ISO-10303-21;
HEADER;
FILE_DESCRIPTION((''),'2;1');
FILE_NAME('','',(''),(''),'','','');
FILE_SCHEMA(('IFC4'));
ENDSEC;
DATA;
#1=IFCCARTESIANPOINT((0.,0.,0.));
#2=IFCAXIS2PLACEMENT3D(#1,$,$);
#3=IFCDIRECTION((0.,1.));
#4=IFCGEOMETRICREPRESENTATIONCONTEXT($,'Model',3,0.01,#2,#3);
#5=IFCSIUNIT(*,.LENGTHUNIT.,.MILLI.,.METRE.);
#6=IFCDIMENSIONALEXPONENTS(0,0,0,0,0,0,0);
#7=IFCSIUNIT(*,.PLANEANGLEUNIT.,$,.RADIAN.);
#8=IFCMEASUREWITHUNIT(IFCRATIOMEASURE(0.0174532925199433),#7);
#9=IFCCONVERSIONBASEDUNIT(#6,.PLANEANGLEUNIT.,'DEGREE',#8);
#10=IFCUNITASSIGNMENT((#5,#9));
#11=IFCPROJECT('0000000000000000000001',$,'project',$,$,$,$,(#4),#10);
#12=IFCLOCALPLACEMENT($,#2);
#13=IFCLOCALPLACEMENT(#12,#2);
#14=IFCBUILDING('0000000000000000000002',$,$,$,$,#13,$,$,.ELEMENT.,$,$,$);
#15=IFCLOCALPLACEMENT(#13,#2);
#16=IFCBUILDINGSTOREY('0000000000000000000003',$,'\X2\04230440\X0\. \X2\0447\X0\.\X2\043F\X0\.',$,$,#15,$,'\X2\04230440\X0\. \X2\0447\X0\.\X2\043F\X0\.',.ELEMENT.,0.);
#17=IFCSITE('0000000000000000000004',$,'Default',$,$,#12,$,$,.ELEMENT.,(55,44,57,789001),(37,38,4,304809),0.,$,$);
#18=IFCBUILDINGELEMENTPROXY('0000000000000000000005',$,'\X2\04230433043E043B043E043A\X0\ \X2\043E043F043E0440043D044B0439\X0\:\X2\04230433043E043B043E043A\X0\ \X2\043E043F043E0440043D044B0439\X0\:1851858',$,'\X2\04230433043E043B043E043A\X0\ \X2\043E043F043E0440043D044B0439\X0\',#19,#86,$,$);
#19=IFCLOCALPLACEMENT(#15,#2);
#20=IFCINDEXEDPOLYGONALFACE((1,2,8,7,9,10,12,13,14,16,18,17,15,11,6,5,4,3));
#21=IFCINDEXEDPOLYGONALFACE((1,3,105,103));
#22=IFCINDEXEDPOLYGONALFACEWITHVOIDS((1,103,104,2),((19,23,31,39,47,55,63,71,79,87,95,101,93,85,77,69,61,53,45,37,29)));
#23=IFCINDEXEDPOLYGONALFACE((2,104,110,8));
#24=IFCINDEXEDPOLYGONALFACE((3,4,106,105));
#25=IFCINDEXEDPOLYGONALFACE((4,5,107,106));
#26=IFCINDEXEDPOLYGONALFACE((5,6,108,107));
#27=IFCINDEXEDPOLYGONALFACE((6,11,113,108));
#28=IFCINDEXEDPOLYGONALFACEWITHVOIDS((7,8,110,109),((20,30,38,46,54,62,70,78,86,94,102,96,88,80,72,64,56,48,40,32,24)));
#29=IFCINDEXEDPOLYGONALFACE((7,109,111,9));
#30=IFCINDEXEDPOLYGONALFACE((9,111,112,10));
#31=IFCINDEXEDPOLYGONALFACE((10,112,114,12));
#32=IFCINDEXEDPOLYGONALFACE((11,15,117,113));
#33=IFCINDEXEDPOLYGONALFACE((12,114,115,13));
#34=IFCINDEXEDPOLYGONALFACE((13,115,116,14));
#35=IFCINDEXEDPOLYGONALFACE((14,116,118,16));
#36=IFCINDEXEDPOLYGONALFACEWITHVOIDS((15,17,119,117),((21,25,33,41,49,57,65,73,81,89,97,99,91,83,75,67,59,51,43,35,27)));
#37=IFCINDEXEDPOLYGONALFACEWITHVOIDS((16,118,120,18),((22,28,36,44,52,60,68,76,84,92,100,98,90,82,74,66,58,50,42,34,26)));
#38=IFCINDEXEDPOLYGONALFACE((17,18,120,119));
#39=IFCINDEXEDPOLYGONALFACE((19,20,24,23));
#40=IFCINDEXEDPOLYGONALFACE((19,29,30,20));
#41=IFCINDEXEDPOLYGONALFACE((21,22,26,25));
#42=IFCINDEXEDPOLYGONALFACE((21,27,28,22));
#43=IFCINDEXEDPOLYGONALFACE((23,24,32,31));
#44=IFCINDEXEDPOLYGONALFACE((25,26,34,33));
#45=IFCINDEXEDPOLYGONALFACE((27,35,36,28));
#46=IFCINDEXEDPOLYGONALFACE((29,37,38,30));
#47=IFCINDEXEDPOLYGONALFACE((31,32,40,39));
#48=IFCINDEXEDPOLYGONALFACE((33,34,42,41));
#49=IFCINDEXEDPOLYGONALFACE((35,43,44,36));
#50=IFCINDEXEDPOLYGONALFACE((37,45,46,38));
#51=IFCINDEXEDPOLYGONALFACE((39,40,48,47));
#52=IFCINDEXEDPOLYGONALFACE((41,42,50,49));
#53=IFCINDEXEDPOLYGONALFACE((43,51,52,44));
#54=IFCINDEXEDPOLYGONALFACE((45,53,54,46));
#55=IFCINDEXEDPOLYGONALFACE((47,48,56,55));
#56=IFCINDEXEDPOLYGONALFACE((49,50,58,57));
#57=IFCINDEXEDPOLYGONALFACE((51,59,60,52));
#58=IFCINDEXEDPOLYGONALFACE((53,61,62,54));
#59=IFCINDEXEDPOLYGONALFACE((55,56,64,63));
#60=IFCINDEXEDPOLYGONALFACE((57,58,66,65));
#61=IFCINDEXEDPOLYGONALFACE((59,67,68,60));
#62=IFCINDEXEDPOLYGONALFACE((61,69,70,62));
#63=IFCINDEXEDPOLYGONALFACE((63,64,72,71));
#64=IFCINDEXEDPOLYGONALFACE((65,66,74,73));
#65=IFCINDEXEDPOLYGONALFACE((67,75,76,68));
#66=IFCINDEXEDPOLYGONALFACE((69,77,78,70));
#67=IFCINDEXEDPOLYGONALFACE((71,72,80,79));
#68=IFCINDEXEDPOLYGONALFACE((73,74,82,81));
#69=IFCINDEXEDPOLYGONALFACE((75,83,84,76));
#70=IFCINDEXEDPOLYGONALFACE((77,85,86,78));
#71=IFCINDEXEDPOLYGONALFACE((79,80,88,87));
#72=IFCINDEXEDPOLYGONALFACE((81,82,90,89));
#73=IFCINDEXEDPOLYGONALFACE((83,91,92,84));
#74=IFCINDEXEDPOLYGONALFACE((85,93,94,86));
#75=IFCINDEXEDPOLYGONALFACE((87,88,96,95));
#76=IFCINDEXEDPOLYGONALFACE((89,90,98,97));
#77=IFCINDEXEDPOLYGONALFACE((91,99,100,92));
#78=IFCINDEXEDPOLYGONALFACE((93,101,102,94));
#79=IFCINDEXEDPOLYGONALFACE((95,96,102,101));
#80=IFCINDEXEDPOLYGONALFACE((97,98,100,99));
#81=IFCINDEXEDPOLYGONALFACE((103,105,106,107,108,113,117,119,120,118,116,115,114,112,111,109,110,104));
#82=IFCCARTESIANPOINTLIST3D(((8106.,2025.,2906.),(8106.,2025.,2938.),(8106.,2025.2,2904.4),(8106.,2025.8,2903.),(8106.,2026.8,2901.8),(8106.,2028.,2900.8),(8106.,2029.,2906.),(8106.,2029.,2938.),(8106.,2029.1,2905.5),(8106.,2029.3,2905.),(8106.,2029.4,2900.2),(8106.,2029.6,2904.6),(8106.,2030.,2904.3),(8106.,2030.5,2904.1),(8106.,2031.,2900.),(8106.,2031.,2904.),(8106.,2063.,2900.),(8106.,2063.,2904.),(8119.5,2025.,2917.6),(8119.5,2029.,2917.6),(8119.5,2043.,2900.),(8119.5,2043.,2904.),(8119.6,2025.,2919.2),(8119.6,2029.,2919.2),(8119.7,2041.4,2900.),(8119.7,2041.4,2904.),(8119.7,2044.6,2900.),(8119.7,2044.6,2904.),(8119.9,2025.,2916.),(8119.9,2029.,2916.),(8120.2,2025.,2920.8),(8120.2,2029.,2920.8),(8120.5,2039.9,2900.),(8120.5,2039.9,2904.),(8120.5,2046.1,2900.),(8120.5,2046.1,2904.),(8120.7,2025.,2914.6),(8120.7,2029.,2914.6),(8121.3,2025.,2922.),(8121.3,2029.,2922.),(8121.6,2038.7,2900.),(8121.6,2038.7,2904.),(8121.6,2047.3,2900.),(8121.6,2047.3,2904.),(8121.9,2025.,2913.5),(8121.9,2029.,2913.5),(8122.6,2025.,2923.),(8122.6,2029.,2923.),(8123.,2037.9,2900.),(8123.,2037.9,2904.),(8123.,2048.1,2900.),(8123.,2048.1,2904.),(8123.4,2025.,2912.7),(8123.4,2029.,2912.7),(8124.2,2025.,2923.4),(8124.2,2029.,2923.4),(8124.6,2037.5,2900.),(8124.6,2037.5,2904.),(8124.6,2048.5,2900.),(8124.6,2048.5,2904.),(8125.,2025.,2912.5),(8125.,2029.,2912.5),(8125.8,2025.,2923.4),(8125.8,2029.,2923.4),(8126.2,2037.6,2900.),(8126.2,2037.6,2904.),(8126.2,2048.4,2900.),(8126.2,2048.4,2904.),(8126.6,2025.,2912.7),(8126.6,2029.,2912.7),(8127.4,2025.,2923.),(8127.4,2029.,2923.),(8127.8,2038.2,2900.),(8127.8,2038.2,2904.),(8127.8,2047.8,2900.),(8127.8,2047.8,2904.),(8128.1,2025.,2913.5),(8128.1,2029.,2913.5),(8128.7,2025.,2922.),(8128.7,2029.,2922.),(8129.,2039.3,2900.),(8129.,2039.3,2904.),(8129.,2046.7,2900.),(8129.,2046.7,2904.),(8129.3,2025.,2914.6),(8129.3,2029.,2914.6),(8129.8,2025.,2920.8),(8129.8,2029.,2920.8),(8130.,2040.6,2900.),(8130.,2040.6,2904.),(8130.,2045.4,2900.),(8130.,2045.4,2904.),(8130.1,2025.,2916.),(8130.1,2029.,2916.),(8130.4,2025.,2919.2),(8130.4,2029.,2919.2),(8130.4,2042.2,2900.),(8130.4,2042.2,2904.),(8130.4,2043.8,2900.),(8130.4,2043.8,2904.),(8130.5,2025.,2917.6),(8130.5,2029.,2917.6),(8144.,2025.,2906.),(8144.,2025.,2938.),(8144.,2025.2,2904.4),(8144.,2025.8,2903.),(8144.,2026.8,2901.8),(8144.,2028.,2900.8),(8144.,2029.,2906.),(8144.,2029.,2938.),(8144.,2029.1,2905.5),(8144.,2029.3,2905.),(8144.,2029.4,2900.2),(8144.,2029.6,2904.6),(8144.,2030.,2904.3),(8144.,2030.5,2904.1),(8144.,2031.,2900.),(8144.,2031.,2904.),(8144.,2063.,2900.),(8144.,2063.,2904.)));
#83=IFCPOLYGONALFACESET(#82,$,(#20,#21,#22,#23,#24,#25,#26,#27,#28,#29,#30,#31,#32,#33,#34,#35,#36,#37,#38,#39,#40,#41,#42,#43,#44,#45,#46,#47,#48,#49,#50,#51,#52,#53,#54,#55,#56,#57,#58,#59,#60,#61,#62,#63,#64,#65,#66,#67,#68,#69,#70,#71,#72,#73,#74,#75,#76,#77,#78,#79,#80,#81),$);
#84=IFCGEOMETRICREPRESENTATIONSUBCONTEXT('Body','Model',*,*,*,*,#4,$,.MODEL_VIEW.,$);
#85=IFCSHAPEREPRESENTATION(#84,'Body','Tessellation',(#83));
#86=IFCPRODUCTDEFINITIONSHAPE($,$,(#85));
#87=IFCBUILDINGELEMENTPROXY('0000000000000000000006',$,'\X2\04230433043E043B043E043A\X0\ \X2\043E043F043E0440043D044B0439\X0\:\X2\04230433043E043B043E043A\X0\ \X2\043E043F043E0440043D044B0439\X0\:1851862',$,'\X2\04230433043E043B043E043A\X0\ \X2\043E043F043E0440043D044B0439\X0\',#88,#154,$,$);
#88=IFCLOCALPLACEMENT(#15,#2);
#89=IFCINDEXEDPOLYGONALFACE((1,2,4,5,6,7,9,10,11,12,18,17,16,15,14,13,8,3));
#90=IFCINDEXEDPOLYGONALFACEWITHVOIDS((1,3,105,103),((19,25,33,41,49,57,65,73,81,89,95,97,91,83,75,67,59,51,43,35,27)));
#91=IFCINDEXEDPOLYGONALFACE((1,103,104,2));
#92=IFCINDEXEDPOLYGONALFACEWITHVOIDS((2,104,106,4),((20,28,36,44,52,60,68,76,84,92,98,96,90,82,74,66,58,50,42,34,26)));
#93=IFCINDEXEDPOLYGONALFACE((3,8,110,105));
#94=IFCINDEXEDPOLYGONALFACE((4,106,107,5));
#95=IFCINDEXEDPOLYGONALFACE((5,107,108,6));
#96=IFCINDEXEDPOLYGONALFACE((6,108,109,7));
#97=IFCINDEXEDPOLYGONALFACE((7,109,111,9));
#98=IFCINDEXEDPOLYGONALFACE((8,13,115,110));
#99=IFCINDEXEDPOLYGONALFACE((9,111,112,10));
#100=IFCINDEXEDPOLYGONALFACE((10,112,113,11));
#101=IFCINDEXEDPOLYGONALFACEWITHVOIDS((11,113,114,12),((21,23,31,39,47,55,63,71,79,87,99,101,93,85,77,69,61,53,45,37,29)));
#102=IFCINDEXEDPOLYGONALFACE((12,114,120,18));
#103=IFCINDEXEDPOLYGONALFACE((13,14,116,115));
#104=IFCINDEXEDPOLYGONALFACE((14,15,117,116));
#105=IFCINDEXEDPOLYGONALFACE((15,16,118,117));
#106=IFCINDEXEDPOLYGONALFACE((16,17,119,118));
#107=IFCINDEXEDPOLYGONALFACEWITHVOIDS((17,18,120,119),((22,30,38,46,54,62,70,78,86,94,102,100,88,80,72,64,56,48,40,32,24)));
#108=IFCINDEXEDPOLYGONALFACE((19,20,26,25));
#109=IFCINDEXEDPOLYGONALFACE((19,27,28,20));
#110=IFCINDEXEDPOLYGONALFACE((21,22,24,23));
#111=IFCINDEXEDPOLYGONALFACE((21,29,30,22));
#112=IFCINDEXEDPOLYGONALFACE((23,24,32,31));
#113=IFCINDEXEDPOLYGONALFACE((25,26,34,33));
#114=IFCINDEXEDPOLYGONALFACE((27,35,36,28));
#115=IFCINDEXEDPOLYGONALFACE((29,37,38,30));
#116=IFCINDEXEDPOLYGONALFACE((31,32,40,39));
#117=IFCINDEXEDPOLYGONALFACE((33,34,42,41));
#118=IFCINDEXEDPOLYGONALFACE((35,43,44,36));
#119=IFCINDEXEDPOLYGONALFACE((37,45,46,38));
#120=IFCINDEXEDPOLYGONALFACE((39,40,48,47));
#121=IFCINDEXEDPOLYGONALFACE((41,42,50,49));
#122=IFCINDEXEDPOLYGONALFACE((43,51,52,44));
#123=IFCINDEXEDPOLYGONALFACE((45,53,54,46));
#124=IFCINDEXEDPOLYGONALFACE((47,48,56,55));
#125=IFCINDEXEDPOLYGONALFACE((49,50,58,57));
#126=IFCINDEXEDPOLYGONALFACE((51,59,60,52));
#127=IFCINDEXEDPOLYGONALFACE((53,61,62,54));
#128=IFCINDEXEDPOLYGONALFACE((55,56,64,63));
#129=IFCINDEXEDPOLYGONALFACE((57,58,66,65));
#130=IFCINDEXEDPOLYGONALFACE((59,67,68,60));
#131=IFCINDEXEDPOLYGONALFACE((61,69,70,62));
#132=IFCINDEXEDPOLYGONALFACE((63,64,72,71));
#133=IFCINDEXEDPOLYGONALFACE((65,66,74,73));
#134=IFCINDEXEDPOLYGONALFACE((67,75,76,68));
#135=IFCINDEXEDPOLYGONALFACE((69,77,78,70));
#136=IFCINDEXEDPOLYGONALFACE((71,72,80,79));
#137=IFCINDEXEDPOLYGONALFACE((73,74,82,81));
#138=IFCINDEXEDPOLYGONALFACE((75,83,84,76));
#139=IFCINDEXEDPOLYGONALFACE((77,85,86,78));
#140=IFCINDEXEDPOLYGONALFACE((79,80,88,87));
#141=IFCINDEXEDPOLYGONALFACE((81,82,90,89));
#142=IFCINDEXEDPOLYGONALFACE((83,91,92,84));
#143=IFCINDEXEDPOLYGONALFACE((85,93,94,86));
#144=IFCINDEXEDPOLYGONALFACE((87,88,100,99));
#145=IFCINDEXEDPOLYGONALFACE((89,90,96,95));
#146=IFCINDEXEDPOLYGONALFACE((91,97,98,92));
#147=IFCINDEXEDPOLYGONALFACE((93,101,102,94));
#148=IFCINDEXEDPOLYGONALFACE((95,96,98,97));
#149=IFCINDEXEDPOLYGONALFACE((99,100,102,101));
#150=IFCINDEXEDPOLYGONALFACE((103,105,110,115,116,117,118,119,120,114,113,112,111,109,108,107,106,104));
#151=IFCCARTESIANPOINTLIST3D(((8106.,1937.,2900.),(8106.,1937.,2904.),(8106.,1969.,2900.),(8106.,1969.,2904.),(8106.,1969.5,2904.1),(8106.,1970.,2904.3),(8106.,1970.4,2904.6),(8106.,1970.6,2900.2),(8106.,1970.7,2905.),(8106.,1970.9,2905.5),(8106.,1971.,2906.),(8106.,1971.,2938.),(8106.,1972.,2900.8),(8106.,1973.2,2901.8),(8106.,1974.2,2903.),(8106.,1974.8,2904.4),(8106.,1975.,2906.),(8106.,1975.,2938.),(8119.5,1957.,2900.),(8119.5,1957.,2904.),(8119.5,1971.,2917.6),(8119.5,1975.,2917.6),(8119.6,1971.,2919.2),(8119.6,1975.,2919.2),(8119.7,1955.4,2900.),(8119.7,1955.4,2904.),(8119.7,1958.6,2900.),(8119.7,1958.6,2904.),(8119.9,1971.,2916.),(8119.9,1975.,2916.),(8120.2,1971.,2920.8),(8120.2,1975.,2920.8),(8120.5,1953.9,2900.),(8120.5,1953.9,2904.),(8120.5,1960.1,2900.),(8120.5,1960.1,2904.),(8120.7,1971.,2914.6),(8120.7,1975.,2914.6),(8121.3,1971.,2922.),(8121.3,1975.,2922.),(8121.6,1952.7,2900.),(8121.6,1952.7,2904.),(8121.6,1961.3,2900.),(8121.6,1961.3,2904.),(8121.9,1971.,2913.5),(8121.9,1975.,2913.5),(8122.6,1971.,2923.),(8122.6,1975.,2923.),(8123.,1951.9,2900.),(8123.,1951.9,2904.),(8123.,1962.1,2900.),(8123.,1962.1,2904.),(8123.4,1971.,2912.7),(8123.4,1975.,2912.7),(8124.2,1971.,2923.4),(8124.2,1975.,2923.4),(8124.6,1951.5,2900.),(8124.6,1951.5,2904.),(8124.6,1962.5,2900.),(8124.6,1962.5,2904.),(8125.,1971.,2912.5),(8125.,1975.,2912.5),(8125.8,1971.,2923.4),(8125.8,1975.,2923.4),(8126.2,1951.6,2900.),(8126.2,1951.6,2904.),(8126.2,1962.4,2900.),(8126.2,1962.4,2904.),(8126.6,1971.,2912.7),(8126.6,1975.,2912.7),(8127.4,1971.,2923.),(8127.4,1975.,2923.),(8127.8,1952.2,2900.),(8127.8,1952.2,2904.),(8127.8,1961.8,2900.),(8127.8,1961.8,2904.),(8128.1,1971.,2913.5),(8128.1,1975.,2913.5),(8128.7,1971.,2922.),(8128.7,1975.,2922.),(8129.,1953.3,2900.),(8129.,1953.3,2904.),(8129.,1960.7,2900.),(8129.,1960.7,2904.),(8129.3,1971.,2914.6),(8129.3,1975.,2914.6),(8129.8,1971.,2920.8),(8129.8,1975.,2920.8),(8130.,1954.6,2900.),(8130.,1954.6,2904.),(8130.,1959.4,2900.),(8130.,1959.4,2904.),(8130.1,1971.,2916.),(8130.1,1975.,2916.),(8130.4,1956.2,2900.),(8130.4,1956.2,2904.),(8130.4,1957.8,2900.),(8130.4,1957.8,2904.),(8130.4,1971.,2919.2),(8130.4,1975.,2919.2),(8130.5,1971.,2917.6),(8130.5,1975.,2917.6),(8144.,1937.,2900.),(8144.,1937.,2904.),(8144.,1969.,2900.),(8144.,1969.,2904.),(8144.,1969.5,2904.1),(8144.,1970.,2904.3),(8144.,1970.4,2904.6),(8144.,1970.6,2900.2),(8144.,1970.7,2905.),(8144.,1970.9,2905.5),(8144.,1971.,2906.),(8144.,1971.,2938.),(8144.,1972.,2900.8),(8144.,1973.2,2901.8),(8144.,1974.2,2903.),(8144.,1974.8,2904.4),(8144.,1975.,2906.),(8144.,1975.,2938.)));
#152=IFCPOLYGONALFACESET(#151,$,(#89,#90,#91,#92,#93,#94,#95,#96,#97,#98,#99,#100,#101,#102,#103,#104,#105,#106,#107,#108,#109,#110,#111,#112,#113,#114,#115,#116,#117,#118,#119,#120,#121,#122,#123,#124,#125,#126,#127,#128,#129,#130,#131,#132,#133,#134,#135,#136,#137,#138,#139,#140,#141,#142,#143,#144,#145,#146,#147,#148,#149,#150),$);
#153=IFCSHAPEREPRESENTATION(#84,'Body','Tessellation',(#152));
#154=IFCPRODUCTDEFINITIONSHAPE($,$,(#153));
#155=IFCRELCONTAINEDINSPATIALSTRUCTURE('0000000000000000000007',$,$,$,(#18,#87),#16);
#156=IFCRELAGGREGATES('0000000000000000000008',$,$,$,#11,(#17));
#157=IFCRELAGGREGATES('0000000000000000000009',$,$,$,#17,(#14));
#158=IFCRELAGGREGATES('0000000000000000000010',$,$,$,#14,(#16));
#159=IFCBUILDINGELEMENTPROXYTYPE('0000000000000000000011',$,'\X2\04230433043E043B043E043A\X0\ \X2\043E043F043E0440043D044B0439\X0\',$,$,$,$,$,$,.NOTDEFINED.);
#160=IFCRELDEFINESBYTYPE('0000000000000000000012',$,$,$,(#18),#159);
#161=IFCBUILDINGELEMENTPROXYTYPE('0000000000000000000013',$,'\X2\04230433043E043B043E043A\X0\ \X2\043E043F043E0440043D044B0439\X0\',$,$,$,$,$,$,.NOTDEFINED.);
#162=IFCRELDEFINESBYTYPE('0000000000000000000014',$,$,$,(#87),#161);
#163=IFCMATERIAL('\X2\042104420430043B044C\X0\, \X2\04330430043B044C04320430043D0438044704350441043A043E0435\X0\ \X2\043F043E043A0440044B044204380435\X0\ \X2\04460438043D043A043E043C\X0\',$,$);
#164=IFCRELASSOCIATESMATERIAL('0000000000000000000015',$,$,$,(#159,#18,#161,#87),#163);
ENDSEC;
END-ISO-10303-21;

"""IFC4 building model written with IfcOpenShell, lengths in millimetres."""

from ifc_helpers import new_model, entity, si_unit, converted_unit, direction, frame, frame_2d, origin, place, context, subcontext, project, spatial, polyline, circle_curve, parameter, trimmed, segment, composite_curve, circle, outline, extrude, source, transform, mapped, material, type_object, type_shapes, element, save


model = new_model("IFC4")

# Units and contexts
model_context = context("Model", 3, precision=0.01, world=origin(), true_north=direction((0.0, 1.0)))
body_context = subcontext(model_context, "Body", "Model", "MODEL_VIEW")
ifc_project = project(units=[si_unit("LENGTHUNIT", "METRE", prefix="MILLI"), converted_unit("PLANEANGLEUNIT", "DEGREE", entity("IfcRatioMeasure", 0.0174532925199433), si_unit("PLANEANGLEUNIT", "RADIAN"), dimensions=[0, 0, 0, 0, 0, 0, 0])], contexts=[model_context])

# Site, building, storey
site_placement = place(None, origin())
site = spatial("IfcSite", under=ifc_project, at=site_placement, Name="Default", CompositionType="ELEMENT", RefLatitude=(55, 44, 57, 789001), RefLongitude=(37, 38, 4, 304809), RefElevation=0.0)
building_placement = place(site_placement, origin())
building = spatial("IfcBuilding", under=site, at=building_placement, CompositionType="ELEMENT")
storey_placement = place(building_placement, origin())
storey = spatial("IfcBuildingStorey", under=building, at=storey_placement, Name="Ур. ч.п.", LongName="Ур. ч.п.", CompositionType="ELEMENT", Elevation=0.0)

# Building element proxies, openings
ifc_material_1 = material(Name="Сталь, гальваническое покрытие цинком")
building_element_proxy_type_1 = type_object("IfcBuildingElementProxyType", Name="Уголок опорный", material=ifc_material_1)
shared_shape_1 = source(origin(), body_context, "Body", "SweptSolid", [
    extrude(outline(composite_curve([segment(polyline([(-6.0, -12.0), (26.0, -12.0)]), True, "CONTINUOUS"), segment(polyline([(26.0, -12.0), (26.0, -8.0)]), True, "CONTINUOUS"), segment(polyline([(26.0, -8.0), (-6.0, -8.0)]), True, "CONTINUOUS"), segment(trimmed(circle_curve(frame_2d((-6.0, -6.0), x_axis=(0.0, -1.0)), 2.0), [parameter(270.0)], [parameter(0.0)], True, "PARAMETER"), False, "CONTINUOUS"), segment(polyline([(-8.0, -6.0), (-8.0, 26.0)]), True, "CONTINUOUS"), segment(polyline([(-8.0, 26.0), (-12.0, 26.0)]), True, "CONTINUOUS"), segment(polyline([(-12.0, 26.0), (-12.0, -6.0)]), True, "CONTINUOUS"), segment(trimmed(circle_curve(frame_2d((-6.0, -6.0), x_axis=(0.0, -1.0)), 6.0), [parameter(270.0)], [parameter(360.0)], True, "PARAMETER"), True, "CONTINUOUS")], self_intersect=False)), frame((12.0, -19.0, 12.0), z_axis=(0.0, 1.0, 0.0), x_axis=(0.0, 0.0, 1.0)), (0.0, 0.0, 1.0), 38.0),
])
type_shapes(building_element_proxy_type_1, [shared_shape_1])
proxy_1_placement = place(storey_placement, frame((8125.0, 2025.0, 2900.0), z_axis=(0.0, 0.0, 1.0), x_axis=(0.0, 1.0, 0.0)))
proxy_1 = element("IfcBuildingElementProxy", 1, at=proxy_1_placement, inside=storey, type_object=building_element_proxy_type_1, material=ifc_material_1, Name="Уголок опорный:Уголок опорный:1851858", ObjectType="Уголок опорный", context=body_context, shape_type="MappedRepresentation", body=[
    mapped(shared_shape_1, transform((0.0, 0.0, 0.0), scale=1.0)),
])
opening_1_placement = place(storey_placement, frame((8125.0, 2025.0, 2900.0), z_axis=(0.0, 0.0, 1.0), x_axis=(-1.0, 0.0, 0.0)))
element("IfcOpeningElement", 2, at=opening_1_placement, cuts=proxy_1, ObjectType="Opening", PredefinedType="OPENING", context=body_context, shape_type="SweptSolid", body=[
    extrude(circle(Radius=5.5, at=frame_2d((0.0, 0.0), x_axis=(1.0, 0.0))), frame((0.0, -4.0, 18.0), z_axis=(0.0, 1.0, 0.0), x_axis=(0.0, 0.0, -1.0)), (0.0, 0.0, 1.0), 4.0),
])
opening_2_placement = place(storey_placement, frame((8125.0, 2025.0, 2900.0), z_axis=(0.0, 0.0, 1.0), x_axis=(-1.0, 0.0, 0.0)))
element("IfcOpeningElement", 3, at=opening_2_placement, cuts=proxy_1, ObjectType="Opening", PredefinedType="OPENING", context=body_context, shape_type="SweptSolid", body=[
    extrude(circle(Radius=5.5, at=frame_2d((0.0, 0.0), x_axis=(1.0, 0.0))), frame((0.0, -18.0, 0.0)), (0.0, 0.0, 1.0), 4.0),
])
building_element_proxy_type_2 = type_object("IfcBuildingElementProxyType", Name="Уголок опорный", material=ifc_material_1)
shared_shape_2 = source(origin(), body_context, "Body", "SweptSolid", [
    extrude(outline(composite_curve([segment(polyline([(-6.0, -12.0), (26.0, -12.0)]), True, "CONTINUOUS"), segment(polyline([(26.0, -12.0), (26.0, -8.0)]), True, "CONTINUOUS"), segment(polyline([(26.0, -8.0), (-6.0, -8.0)]), True, "CONTINUOUS"), segment(trimmed(circle_curve(frame_2d((-6.0, -6.0), x_axis=(0.0, -1.0)), 2.0), [parameter(270.0)], [parameter(0.0)], True, "PARAMETER"), False, "CONTINUOUS"), segment(polyline([(-8.0, -6.0), (-8.0, 26.0)]), True, "CONTINUOUS"), segment(polyline([(-8.0, 26.0), (-12.0, 26.0)]), True, "CONTINUOUS"), segment(polyline([(-12.0, 26.0), (-12.0, -6.0)]), True, "CONTINUOUS"), segment(trimmed(circle_curve(frame_2d((-6.0, -6.0), x_axis=(0.0, -1.0)), 6.0), [parameter(270.0)], [parameter(360.0)], True, "PARAMETER"), True, "CONTINUOUS")], self_intersect=False)), frame((12.0, -19.0, 12.0), z_axis=(0.0, 1.0, 0.0), x_axis=(0.0, 0.0, 1.0)), (0.0, 0.0, 1.0), 38.0),
])
type_shapes(building_element_proxy_type_2, [shared_shape_2])
proxy_2_placement = place(storey_placement, frame((8125.0, 1975.0, 2900.0), z_axis=(0.0, 0.0, 1.0), x_axis=(0.0, -1.0, 0.0)))
proxy_2 = element("IfcBuildingElementProxy", 4, at=proxy_2_placement, inside=storey, type_object=building_element_proxy_type_2, material=ifc_material_1, Name="Уголок опорный:Уголок опорный:1851862", ObjectType="Уголок опорный", context=body_context, shape_type="MappedRepresentation", body=[
    mapped(shared_shape_2, transform((0.0, 0.0, 0.0), scale=1.0)),
])
opening_3_placement = place(storey_placement, frame((8125.0, 1975.0, 2900.0), z_axis=(0.0, 0.0, 1.0), x_axis=(-1.0, 0.0, 0.0)))
element("IfcOpeningElement", 5, at=opening_3_placement, cuts=proxy_2, ObjectType="Opening", PredefinedType="OPENING", context=body_context, shape_type="SweptSolid", body=[
    extrude(circle(Radius=5.5, at=frame_2d((0.0, 0.0), x_axis=(1.0, 0.0))), frame((0.0, 4.0, 18.0), z_axis=(0.0, -1.0, 0.0), x_axis=(0.0, 0.0, -1.0)), (0.0, 0.0, 1.0), 4.0),
])
opening_4_placement = place(storey_placement, frame((8125.0, 1975.0, 2900.0), z_axis=(0.0, 0.0, 1.0), x_axis=(-1.0, 0.0, 0.0)))
element("IfcOpeningElement", 6, at=opening_4_placement, cuts=proxy_2, ObjectType="Opening", PredefinedType="OPENING", context=body_context, shape_type="SweptSolid", body=[
    extrude(circle(Radius=5.5, at=frame_2d((0.0, 0.0), x_axis=(1.0, 0.0))), frame((0.0, 18.0, 0.0)), (0.0, 0.0, 1.0), 4.0),
])

save(model, "model.ifc")
